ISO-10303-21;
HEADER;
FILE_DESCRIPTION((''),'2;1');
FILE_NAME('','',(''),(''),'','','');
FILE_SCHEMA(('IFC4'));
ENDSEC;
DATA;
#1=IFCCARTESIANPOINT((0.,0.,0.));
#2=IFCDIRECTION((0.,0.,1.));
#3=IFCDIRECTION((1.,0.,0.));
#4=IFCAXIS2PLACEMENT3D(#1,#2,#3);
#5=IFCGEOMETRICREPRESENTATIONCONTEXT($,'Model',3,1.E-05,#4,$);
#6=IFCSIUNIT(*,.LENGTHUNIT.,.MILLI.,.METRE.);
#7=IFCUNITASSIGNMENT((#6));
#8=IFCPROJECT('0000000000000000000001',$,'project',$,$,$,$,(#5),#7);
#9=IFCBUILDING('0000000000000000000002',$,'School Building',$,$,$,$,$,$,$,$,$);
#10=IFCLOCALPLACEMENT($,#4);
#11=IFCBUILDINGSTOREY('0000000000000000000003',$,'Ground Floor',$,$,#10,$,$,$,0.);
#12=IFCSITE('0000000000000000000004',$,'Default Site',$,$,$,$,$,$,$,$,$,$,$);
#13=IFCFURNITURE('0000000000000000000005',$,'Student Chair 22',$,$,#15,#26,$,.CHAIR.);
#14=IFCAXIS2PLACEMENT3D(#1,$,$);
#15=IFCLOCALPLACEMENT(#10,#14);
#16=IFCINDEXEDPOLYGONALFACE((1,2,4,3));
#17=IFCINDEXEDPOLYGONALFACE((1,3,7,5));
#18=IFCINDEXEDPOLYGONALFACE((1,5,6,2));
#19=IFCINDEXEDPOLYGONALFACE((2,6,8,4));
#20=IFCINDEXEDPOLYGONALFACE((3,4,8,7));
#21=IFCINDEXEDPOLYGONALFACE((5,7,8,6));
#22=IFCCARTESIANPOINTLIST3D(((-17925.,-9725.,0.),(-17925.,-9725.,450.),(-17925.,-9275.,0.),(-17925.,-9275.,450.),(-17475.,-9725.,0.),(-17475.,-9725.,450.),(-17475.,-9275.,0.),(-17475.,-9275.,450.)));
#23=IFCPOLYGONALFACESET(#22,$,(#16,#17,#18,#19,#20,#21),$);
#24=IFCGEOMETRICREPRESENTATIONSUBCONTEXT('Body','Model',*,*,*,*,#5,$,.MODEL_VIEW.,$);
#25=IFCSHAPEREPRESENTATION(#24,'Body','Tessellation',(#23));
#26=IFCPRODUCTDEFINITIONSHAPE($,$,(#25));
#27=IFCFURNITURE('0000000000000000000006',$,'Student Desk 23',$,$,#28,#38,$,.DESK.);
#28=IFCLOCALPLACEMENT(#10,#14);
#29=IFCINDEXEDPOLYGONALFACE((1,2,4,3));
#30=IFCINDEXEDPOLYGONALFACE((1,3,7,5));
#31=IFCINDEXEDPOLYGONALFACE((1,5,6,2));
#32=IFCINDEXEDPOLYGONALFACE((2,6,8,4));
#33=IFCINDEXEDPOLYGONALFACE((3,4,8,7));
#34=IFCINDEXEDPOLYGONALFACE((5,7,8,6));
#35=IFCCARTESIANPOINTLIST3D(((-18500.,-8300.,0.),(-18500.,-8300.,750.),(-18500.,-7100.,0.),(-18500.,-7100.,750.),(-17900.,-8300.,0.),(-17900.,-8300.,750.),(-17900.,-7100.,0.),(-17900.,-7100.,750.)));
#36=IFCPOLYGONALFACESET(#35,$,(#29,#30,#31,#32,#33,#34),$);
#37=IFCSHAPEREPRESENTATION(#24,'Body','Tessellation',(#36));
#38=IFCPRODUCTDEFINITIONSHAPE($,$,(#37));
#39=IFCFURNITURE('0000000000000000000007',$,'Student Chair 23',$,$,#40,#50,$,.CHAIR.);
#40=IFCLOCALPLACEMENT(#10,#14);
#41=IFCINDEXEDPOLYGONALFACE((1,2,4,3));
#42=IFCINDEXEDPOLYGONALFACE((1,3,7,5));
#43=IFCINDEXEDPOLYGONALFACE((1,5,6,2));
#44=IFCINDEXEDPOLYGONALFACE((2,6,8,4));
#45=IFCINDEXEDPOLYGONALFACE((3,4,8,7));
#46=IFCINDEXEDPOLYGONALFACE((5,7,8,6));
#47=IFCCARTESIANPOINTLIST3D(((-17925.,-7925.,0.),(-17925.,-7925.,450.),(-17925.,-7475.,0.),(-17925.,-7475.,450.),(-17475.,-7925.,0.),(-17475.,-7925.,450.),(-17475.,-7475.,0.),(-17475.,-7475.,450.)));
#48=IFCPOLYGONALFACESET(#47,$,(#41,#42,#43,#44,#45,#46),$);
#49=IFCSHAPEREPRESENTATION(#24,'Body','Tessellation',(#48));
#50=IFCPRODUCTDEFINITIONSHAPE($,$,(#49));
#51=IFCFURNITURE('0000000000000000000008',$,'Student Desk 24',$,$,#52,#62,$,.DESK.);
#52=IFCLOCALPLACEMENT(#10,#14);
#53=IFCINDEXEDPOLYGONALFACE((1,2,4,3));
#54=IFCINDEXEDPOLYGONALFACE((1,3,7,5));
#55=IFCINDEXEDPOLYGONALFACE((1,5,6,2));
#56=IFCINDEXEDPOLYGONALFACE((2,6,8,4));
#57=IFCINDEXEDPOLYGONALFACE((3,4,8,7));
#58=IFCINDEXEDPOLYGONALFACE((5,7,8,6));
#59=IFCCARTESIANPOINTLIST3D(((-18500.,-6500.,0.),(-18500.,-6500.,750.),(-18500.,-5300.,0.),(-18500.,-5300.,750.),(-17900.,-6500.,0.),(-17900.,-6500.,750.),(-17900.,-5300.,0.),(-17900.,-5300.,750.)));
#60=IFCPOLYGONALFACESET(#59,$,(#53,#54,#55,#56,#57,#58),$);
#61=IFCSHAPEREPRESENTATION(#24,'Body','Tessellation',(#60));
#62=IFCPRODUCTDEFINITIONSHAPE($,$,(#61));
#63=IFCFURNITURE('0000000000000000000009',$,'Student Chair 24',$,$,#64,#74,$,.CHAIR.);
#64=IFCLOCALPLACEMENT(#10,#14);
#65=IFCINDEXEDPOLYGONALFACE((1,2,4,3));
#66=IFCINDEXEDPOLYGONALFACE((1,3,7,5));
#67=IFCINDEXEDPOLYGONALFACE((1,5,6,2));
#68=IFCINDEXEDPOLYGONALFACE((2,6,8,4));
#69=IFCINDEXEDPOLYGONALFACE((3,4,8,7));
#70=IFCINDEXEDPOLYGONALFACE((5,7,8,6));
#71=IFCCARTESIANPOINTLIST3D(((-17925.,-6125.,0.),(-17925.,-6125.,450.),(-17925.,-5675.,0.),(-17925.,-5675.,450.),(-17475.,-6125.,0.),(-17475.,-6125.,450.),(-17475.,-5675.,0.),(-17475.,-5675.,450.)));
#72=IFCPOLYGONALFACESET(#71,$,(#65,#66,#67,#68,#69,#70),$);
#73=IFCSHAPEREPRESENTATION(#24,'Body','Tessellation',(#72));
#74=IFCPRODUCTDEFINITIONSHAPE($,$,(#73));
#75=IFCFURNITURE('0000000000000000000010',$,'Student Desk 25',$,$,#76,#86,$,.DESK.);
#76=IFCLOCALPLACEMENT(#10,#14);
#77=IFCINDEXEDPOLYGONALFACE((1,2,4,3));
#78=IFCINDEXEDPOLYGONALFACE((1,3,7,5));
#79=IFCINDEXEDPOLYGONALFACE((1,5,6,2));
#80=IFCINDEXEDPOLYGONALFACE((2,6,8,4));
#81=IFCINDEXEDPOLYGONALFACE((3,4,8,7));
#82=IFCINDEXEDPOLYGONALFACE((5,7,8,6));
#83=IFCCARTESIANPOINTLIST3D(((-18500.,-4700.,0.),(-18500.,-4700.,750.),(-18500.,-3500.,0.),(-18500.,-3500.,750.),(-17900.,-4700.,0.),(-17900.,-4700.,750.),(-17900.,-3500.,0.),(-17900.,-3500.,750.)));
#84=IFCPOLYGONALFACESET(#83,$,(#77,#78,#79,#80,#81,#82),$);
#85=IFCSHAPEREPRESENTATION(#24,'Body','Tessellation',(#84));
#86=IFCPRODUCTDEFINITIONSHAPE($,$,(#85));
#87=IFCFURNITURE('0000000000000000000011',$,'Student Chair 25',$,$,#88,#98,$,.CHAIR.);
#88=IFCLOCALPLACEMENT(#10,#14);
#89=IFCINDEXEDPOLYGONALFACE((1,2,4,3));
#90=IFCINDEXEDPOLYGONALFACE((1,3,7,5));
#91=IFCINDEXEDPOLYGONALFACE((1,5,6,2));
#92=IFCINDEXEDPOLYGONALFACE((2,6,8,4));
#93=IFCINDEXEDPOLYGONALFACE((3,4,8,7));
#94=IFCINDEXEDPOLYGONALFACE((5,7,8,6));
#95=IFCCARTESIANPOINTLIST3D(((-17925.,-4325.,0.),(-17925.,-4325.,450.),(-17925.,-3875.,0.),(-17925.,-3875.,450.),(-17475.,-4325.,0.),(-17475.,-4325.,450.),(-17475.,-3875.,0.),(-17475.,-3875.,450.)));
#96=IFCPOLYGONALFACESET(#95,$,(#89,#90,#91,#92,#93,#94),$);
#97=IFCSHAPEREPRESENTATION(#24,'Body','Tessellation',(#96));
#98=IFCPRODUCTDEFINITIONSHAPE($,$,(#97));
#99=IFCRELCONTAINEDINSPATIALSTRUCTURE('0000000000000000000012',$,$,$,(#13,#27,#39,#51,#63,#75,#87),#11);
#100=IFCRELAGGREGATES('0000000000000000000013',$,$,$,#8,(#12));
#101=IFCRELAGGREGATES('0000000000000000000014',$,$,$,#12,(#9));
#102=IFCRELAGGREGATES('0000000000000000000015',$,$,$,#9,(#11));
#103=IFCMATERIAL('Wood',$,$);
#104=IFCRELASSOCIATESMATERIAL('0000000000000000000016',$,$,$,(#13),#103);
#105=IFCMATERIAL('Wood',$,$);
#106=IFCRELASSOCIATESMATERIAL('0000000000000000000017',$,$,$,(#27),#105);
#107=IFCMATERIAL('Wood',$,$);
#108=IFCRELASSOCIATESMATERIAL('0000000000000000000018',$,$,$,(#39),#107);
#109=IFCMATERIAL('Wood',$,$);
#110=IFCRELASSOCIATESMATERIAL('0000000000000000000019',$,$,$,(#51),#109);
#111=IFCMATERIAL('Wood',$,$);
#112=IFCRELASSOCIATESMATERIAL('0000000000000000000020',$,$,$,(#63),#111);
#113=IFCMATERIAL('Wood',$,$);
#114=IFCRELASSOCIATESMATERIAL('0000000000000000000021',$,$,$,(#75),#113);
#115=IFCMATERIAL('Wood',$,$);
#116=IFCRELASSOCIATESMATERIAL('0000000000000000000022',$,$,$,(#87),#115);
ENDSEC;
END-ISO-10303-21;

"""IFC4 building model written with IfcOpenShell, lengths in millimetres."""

from ifc_helpers import new_model, si_unit, frame, origin_with_axes, origin_2d, place, context, subcontext, project, spatial, rectangle, extrude, material, element, save


model = new_model("IFC4")

# Units and contexts
model_context = context("Model", 3, precision=1e-05, world=origin_with_axes())
body_context = subcontext(model_context, "Body", "Model", "MODEL_VIEW")
ifc_project = project(units=[si_unit("LENGTHUNIT", "METRE", prefix="MILLI")], contexts=[model_context])

# Site, building, storey
site = spatial("IfcSite", under=ifc_project, Name="Default Site")
building = spatial("IfcBuilding", under=site, Name="School Building")
storey_placement = place(None, origin_with_axes())
storey = spatial("IfcBuildingStorey", under=building, at=storey_placement, Name="Ground Floor", Elevation=0.0)

# Furniture
ifc_material_1 = material(Name="Wood")
furniture_1_placement = place(storey_placement, frame((-17700.0, -9500.0, 0.0), z_axis=(0.0, 0.0, 1.0), x_axis=(1.0, 0.0, 0.0)))
element("IfcFurniture", 1, at=furniture_1_placement, inside=storey, material=ifc_material_1, Name="Student Chair 22", PredefinedType="CHAIR", context=body_context, shape_type="SweptSolid", body=[
    extrude(rectangle(XDim=450.0, YDim=450.0, at=origin_2d()), origin_with_axes(), (0.0, 0.0, 1.0), 450.0),
])
ifc_material_2 = material(Name="Wood")
furniture_2_placement = place(storey_placement, frame((-18200.0, -7700.0, 0.0), z_axis=(0.0, 0.0, 1.0), x_axis=(0.0, 1.0, 0.0)))
element("IfcFurniture", 2, at=furniture_2_placement, inside=storey, material=ifc_material_2, Name="Student Desk 23", PredefinedType="DESK", context=body_context, shape_type="SweptSolid", body=[
    extrude(rectangle(XDim=1200.0, YDim=600.0, at=origin_2d()), origin_with_axes(), (0.0, 0.0, 1.0), 750.0),
])
ifc_material_3 = material(Name="Wood")
furniture_3_placement = place(storey_placement, frame((-17700.0, -7700.0, 0.0), z_axis=(0.0, 0.0, 1.0), x_axis=(1.0, 0.0, 0.0)))
element("IfcFurniture", 3, at=furniture_3_placement, inside=storey, material=ifc_material_3, Name="Student Chair 23", PredefinedType="CHAIR", context=body_context, shape_type="SweptSolid", body=[
    extrude(rectangle(XDim=450.0, YDim=450.0, at=origin_2d()), origin_with_axes(), (0.0, 0.0, 1.0), 450.0),
])
ifc_material_4 = material(Name="Wood")
furniture_4_placement = place(storey_placement, frame((-18200.0, -5900.0, 0.0), z_axis=(0.0, 0.0, 1.0), x_axis=(0.0, 1.0, 0.0)))
element("IfcFurniture", 4, at=furniture_4_placement, inside=storey, material=ifc_material_4, Name="Student Desk 24", PredefinedType="DESK", context=body_context, shape_type="SweptSolid", body=[
    extrude(rectangle(XDim=1200.0, YDim=600.0, at=origin_2d()), origin_with_axes(), (0.0, 0.0, 1.0), 750.0),
])
ifc_material_5 = material(Name="Wood")
furniture_5_placement = place(storey_placement, frame((-17700.0, -5900.0, 0.0), z_axis=(0.0, 0.0, 1.0), x_axis=(1.0, 0.0, 0.0)))
element("IfcFurniture", 5, at=furniture_5_placement, inside=storey, material=ifc_material_5, Name="Student Chair 24", PredefinedType="CHAIR", context=body_context, shape_type="SweptSolid", body=[
    extrude(rectangle(XDim=450.0, YDim=450.0, at=origin_2d()), origin_with_axes(), (0.0, 0.0, 1.0), 450.0),
])
ifc_material_6 = material(Name="Wood")
furniture_6_placement = place(storey_placement, frame((-18200.0, -4100.0, 0.0), z_axis=(0.0, 0.0, 1.0), x_axis=(0.0, 1.0, 0.0)))
element("IfcFurniture", 6, at=furniture_6_placement, inside=storey, material=ifc_material_6, Name="Student Desk 25", PredefinedType="DESK", context=body_context, shape_type="SweptSolid", body=[
    extrude(rectangle(XDim=1200.0, YDim=600.0, at=origin_2d()), origin_with_axes(), (0.0, 0.0, 1.0), 750.0),
])
ifc_material_7 = material(Name="Wood")
furniture_7_placement = place(storey_placement, frame((-17700.0, -4100.0, 0.0), z_axis=(0.0, 0.0, 1.0), x_axis=(1.0, 0.0, 0.0)))
element("IfcFurniture", 7, at=furniture_7_placement, inside=storey, material=ifc_material_7, Name="Student Chair 25", PredefinedType="CHAIR", context=body_context, shape_type="SweptSolid", body=[
    extrude(rectangle(XDim=450.0, YDim=450.0, at=origin_2d()), origin_with_axes(), (0.0, 0.0, 1.0), 450.0),
])

save(model, "model.ifc")
